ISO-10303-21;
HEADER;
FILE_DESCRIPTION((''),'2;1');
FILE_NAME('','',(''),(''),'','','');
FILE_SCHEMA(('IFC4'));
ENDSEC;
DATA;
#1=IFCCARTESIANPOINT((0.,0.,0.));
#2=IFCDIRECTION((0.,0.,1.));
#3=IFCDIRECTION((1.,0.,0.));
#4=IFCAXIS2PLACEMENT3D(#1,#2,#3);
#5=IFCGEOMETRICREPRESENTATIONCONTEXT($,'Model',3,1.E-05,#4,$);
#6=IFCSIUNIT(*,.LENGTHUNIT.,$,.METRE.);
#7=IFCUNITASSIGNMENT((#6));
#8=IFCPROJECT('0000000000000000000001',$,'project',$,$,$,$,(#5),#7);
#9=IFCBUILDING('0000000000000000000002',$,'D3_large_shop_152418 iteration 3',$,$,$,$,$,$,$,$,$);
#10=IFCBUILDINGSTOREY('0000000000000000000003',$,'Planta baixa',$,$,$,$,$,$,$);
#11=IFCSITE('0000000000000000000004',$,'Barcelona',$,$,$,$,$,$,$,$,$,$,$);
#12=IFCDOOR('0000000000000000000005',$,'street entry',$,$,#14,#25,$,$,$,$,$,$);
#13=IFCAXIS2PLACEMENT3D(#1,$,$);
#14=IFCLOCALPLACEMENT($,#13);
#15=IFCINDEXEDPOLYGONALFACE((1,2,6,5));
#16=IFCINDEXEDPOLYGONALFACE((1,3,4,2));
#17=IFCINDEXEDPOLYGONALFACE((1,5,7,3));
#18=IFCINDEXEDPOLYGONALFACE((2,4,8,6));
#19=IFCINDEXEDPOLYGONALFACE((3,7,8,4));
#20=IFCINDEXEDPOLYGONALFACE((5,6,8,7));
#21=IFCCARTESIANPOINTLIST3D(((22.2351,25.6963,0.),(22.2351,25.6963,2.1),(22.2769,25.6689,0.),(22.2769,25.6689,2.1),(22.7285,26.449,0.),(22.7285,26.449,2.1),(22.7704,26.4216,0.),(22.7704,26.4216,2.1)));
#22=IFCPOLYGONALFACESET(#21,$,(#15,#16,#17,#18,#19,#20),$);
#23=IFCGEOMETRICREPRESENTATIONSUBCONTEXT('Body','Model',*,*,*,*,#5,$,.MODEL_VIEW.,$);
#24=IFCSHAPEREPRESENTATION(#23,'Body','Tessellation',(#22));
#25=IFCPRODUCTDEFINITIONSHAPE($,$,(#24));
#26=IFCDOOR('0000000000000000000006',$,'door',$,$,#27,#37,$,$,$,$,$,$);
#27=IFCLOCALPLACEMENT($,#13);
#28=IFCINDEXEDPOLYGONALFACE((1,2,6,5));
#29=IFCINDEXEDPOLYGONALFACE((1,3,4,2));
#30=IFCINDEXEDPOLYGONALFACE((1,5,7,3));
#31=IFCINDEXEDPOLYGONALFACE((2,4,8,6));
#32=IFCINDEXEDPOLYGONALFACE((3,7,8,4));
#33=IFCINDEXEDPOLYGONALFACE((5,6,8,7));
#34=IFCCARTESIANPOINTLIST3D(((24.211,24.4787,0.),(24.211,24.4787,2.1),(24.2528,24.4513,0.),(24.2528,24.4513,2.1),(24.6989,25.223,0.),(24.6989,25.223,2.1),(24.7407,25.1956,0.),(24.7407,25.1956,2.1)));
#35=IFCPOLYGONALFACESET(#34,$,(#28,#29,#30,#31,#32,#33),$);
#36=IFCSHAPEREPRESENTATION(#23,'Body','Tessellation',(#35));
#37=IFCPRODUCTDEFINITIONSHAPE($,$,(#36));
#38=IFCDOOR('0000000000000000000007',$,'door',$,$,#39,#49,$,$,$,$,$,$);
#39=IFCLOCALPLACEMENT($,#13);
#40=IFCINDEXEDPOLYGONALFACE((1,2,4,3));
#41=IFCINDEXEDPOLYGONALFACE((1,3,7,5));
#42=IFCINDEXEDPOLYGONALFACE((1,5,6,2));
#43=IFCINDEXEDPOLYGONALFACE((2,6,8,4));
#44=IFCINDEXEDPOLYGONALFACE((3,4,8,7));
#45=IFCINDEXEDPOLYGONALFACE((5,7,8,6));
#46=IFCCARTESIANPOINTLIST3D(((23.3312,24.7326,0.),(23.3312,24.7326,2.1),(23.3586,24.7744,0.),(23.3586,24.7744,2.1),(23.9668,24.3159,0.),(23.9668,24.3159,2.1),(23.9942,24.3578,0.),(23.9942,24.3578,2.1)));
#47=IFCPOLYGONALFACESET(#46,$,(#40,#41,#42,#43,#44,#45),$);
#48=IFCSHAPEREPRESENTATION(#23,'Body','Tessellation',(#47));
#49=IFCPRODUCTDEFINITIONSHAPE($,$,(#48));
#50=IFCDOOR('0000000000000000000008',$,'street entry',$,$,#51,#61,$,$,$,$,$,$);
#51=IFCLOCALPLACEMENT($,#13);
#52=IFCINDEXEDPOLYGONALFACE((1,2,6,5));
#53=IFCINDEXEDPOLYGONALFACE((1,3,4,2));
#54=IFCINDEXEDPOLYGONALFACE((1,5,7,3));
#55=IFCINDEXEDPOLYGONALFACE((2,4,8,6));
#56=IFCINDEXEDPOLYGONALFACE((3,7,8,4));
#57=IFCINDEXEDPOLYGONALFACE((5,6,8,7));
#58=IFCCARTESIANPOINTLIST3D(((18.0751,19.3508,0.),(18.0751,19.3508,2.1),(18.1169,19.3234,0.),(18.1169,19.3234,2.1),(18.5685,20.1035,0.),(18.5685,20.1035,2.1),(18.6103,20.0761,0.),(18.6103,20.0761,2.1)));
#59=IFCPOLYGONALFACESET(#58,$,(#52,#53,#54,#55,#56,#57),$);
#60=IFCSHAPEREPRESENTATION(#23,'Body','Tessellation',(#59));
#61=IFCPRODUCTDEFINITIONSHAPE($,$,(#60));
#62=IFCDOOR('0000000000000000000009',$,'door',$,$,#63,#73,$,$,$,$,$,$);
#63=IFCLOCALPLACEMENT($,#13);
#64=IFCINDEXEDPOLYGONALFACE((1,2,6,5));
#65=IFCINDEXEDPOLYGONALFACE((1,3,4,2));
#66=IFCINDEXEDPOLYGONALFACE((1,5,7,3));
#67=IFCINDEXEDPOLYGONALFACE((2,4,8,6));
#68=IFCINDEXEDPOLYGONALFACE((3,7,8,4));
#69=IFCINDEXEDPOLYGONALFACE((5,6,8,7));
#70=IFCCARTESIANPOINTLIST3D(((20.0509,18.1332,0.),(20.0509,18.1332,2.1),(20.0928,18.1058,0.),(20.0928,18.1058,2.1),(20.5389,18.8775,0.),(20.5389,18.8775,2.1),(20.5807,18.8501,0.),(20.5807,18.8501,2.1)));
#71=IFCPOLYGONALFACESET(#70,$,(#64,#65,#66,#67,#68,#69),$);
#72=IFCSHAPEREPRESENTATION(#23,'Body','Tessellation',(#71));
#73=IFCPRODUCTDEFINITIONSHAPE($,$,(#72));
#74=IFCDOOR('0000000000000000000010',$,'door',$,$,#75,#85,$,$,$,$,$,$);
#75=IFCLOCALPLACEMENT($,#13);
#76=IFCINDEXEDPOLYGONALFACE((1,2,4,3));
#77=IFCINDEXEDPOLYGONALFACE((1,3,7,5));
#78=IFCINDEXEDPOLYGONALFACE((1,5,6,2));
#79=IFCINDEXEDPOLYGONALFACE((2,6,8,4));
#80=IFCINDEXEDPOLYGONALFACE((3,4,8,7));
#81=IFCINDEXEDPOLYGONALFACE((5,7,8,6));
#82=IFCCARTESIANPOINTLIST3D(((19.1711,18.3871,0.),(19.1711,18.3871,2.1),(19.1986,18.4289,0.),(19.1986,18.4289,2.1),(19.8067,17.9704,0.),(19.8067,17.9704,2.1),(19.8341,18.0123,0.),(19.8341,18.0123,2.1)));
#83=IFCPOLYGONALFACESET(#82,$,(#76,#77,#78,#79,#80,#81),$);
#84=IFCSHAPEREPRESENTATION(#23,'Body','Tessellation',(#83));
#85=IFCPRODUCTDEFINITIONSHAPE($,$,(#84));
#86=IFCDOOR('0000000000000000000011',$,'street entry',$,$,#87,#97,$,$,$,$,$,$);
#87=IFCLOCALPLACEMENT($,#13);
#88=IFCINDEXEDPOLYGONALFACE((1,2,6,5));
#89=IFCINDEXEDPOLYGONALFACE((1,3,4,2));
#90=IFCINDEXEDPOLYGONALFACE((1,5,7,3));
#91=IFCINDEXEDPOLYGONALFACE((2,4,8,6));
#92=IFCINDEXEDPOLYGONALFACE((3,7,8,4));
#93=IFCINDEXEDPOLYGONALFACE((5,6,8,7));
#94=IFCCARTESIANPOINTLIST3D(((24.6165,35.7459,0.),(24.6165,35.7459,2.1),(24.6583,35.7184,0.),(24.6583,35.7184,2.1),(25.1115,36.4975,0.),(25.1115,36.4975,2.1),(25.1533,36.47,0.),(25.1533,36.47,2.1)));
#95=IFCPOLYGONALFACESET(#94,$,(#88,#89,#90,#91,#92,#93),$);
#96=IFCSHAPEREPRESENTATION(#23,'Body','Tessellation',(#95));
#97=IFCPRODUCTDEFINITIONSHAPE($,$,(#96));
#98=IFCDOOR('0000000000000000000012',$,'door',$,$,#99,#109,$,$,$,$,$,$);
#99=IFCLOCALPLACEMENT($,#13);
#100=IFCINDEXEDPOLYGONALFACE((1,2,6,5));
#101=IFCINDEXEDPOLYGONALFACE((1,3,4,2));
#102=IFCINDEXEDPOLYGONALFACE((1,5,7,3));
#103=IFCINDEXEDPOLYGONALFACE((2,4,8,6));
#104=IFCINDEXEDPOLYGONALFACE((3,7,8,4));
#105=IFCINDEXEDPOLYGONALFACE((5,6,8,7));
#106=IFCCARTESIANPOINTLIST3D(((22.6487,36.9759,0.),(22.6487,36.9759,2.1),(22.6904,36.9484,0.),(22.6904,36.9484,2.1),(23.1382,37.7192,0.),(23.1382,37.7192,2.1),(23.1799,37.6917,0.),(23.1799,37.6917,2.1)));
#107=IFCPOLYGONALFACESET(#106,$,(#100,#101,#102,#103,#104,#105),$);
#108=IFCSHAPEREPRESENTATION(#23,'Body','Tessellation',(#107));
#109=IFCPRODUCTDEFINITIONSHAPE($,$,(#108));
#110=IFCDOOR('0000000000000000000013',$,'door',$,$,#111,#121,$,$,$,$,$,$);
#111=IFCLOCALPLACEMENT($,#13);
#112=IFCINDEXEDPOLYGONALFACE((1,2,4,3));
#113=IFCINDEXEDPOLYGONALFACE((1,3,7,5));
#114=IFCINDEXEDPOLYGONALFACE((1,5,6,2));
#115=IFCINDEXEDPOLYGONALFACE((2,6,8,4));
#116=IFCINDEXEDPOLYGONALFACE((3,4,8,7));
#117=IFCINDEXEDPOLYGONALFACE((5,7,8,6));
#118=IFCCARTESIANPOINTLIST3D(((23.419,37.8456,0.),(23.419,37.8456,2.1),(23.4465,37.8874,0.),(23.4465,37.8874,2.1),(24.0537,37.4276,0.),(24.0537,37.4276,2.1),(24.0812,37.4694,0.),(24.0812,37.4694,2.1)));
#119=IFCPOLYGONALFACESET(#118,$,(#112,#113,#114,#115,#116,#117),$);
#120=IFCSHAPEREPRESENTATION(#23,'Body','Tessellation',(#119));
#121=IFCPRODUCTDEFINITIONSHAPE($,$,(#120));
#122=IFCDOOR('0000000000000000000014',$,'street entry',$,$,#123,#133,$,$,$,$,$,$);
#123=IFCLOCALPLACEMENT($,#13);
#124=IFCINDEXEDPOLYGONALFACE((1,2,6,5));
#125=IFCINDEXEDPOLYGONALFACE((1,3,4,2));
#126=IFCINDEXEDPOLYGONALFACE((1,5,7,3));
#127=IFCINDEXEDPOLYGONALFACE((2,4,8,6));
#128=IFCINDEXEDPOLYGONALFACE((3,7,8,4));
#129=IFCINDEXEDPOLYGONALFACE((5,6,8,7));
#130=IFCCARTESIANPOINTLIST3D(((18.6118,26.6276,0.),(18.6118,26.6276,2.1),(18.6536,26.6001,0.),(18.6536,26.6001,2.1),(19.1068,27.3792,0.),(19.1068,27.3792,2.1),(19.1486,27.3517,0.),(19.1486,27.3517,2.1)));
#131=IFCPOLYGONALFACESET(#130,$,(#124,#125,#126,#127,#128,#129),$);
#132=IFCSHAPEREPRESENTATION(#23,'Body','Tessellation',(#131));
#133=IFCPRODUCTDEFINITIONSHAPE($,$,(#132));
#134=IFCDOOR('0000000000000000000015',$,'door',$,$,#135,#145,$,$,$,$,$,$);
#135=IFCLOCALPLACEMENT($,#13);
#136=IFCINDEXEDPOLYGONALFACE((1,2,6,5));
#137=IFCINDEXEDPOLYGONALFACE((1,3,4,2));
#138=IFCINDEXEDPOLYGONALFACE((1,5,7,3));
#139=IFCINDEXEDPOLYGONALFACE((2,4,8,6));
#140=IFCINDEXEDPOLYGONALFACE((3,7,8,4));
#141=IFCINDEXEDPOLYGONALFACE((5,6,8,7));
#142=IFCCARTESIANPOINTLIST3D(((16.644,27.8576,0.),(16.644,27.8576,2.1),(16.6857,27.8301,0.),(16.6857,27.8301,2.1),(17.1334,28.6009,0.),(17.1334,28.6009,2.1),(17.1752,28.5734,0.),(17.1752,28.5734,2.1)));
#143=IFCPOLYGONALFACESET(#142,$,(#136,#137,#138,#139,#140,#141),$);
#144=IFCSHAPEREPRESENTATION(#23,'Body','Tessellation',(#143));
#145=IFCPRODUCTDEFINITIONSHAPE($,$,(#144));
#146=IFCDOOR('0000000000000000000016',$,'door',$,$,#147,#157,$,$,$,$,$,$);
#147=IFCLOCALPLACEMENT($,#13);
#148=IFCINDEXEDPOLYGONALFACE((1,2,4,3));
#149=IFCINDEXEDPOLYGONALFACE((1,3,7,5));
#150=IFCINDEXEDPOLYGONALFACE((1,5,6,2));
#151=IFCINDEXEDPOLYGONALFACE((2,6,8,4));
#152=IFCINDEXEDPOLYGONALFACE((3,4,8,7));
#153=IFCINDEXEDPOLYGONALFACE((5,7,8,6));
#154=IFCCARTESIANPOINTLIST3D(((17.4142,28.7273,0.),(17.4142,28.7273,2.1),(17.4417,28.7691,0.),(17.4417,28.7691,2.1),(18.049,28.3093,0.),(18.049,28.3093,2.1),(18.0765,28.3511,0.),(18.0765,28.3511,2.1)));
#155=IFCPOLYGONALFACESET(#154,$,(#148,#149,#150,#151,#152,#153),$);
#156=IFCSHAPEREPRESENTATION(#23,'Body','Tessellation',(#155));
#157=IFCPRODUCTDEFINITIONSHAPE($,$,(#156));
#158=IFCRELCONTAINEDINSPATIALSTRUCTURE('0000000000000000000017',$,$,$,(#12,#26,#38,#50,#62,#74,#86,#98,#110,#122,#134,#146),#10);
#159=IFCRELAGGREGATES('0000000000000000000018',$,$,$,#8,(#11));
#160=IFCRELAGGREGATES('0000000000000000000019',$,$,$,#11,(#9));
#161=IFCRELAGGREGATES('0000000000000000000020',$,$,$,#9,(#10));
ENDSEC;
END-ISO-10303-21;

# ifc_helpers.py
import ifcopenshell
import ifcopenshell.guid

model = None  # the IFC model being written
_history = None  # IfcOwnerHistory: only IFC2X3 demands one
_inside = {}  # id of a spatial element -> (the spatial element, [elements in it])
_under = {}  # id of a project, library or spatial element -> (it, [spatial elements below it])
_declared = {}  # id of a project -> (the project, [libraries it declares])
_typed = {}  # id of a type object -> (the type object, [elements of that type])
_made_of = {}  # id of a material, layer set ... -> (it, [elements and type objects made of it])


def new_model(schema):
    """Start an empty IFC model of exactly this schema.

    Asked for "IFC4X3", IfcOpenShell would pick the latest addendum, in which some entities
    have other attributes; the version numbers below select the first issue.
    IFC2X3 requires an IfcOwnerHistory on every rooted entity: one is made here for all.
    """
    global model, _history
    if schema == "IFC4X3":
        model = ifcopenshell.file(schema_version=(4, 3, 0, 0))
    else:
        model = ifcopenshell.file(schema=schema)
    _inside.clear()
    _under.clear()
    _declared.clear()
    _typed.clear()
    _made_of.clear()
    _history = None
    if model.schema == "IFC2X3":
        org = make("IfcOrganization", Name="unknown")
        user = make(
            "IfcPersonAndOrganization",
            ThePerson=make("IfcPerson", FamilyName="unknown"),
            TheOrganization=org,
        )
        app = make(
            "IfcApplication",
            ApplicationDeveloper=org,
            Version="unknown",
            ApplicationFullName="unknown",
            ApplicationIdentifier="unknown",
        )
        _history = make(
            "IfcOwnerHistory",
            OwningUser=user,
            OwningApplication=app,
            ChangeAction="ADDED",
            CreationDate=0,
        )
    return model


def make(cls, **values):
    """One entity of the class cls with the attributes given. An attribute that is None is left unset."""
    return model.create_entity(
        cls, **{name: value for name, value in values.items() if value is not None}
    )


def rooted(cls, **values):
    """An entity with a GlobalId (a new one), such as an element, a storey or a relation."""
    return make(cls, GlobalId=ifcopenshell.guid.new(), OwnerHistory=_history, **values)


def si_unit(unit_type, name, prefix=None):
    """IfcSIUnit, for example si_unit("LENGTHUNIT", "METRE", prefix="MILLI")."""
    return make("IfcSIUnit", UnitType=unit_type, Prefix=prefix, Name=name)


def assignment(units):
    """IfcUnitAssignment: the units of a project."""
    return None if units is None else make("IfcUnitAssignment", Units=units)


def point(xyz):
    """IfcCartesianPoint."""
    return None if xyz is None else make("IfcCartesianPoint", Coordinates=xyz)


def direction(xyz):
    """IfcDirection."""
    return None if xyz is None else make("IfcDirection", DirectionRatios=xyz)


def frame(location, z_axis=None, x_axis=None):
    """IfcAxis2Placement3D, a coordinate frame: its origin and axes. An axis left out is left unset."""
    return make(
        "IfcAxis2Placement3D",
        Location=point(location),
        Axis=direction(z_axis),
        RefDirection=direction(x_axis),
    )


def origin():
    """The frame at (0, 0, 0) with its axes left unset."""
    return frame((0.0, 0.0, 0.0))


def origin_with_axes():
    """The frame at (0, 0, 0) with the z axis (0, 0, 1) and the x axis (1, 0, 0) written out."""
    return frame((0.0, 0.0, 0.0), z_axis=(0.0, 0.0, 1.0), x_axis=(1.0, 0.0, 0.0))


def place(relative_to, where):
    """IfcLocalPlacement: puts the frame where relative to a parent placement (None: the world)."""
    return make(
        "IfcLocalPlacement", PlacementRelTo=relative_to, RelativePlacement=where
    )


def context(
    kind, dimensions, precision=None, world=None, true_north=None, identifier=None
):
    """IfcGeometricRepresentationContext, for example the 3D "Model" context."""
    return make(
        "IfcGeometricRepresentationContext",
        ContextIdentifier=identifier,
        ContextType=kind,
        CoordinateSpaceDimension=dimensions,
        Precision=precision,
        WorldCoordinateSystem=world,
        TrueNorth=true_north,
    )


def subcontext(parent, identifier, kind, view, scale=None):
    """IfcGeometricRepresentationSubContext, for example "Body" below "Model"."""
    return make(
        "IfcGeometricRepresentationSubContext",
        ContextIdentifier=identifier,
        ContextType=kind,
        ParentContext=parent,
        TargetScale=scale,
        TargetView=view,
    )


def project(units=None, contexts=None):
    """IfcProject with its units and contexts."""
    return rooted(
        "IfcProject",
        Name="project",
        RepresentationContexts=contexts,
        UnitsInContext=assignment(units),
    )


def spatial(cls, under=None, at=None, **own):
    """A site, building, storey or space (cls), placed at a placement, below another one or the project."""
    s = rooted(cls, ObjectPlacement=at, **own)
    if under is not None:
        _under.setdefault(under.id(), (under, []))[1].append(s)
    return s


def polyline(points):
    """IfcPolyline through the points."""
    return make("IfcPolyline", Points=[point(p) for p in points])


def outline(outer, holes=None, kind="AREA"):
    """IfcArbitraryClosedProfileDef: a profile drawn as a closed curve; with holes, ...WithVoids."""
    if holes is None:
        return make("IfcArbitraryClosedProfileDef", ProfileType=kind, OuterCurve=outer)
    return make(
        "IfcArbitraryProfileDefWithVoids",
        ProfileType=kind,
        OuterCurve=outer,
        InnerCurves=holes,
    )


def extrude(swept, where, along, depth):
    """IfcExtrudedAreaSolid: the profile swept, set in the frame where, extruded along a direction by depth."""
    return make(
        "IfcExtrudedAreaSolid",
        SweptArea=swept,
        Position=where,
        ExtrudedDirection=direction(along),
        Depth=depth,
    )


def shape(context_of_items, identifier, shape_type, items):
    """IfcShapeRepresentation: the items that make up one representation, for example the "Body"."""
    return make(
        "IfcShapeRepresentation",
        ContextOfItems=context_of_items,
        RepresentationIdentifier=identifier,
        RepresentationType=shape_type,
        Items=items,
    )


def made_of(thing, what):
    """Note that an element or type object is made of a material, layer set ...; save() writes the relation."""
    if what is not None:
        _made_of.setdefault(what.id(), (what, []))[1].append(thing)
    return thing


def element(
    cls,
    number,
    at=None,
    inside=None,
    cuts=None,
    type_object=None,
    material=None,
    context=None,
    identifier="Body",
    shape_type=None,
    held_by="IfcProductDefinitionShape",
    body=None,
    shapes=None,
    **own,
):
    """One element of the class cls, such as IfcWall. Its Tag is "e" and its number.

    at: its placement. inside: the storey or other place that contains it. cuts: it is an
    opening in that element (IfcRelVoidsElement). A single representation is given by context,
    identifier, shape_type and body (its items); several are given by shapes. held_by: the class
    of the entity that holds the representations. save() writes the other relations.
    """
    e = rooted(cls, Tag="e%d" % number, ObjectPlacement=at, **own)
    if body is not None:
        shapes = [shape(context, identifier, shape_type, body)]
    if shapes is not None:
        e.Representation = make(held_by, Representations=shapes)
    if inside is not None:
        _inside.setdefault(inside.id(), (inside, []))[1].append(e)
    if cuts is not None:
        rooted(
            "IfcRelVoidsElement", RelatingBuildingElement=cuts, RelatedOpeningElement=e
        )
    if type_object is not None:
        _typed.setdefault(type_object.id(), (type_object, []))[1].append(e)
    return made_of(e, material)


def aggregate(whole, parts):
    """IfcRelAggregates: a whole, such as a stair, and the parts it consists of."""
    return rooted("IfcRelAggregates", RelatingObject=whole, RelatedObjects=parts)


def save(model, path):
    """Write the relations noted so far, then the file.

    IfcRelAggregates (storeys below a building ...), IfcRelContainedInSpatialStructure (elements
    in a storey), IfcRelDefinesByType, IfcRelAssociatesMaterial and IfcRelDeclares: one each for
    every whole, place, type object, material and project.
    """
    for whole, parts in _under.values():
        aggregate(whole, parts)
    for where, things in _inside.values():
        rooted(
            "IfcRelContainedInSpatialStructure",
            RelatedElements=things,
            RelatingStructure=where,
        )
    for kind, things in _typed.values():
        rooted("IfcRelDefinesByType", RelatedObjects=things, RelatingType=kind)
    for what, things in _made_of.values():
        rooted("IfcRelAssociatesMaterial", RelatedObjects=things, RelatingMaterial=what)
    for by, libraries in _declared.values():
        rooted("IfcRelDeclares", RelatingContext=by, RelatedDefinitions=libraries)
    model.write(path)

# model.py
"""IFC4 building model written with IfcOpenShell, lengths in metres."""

from ifc_helpers import new_model, si_unit, origin, origin_with_axes, place, context, subcontext, project, spatial, polyline, outline, extrude, element, save


model = new_model("IFC4")

# Units and contexts
model_context = context("Model", 3, precision=1e-05, world=origin_with_axes())
body_context = subcontext(model_context, "Body", "Model", "MODEL_VIEW")
ifc_project = project(units=[si_unit("LENGTHUNIT", "METRE")], contexts=[model_context])

# Site, building, storey
site = spatial("IfcSite", under=ifc_project, Name="Barcelona")
building = spatial("IfcBuilding", under=site, Name="D3_large_shop_152418 iteration 3")
storey = spatial("IfcBuildingStorey", under=building, Name="Planta baixa")

# Doors
door_1_placement = place(None, origin_with_axes())
element("IfcDoor", 1, at=door_1_placement, inside=storey, Name="street entry", context=body_context, shape_type="SweptSolid", body=[
    extrude(outline(polyline([(22.7704, 26.4216), (22.2769, 25.6689), (22.2351, 25.6963), (22.7285, 26.449), (22.7704, 26.4216)])), origin(), (0.0, 0.0, 1.0), 2.1),
])
door_2_placement = place(None, origin_with_axes())
element("IfcDoor", 2, at=door_2_placement, inside=storey, Name="door", context=body_context, shape_type="SweptSolid", body=[
    extrude(outline(polyline([(24.211, 24.4787), (24.6989, 25.223), (24.7407, 25.1956), (24.2528, 24.4513), (24.211, 24.4787)])), origin(), (0.0, 0.0, 1.0), 2.1),
])
door_3_placement = place(None, origin_with_axes())
element("IfcDoor", 3, at=door_3_placement, inside=storey, Name="door", context=body_context, shape_type="SweptSolid", body=[
    extrude(outline(polyline([(23.9668, 24.3159), (23.3312, 24.7326), (23.3586, 24.7744), (23.9942, 24.3578), (23.9668, 24.3159)])), origin(), (0.0, 0.0, 1.0), 2.1),
])
door_4_placement = place(None, origin_with_axes())
element("IfcDoor", 4, at=door_4_placement, inside=storey, Name="street entry", context=body_context, shape_type="SweptSolid", body=[
    extrude(outline(polyline([(18.6103, 20.0761), (18.1169, 19.3234), (18.0751, 19.3508), (18.5685, 20.1035), (18.6103, 20.0761)])), origin(), (0.0, 0.0, 1.0), 2.1),
])
door_5_placement = place(None, origin_with_axes())
element("IfcDoor", 5, at=door_5_placement, inside=storey, Name="door", context=body_context, shape_type="SweptSolid", body=[
    extrude(outline(polyline([(20.0509, 18.1332), (20.5389, 18.8775), (20.5807, 18.8501), (20.0928, 18.1058), (20.0509, 18.1332)])), origin(), (0.0, 0.0, 1.0), 2.1),
])
door_6_placement = place(None, origin_with_axes())
element("IfcDoor", 6, at=door_6_placement, inside=storey, Name="door", context=body_context, shape_type="SweptSolid", body=[
    extrude(outline(polyline([(19.8067, 17.9704), (19.1711, 18.3871), (19.1986, 18.4289), (19.8341, 18.0123), (19.8067, 17.9704)])), origin(), (0.0, 0.0, 1.0), 2.1),
])
door_7_placement = place(None, origin_with_axes())
element("IfcDoor", 7, at=door_7_placement, inside=storey, Name="street entry", context=body_context, shape_type="SweptSolid", body=[
    extrude(outline(polyline([(24.6165, 35.7459), (25.1115, 36.4975), (25.1533, 36.47), (24.6583, 35.7184), (24.6165, 35.7459)])), origin(), (0.0, 0.0, 1.0), 2.1),
])
door_8_placement = place(None, origin_with_axes())
element("IfcDoor", 8, at=door_8_placement, inside=storey, Name="door", context=body_context, shape_type="SweptSolid", body=[
    extrude(outline(polyline([(22.6487, 36.9759), (23.1382, 37.7192), (23.1799, 37.6917), (22.6904, 36.9484), (22.6487, 36.9759)])), origin(), (0.0, 0.0, 1.0), 2.1),
])
door_9_placement = place(None, origin_with_axes())
element("IfcDoor", 9, at=door_9_placement, inside=storey, Name="door", context=body_context, shape_type="SweptSolid", body=[
    extrude(outline(polyline([(23.4465, 37.8874), (24.0812, 37.4694), (24.0537, 37.4276), (23.419, 37.8456), (23.4465, 37.8874)])), origin(), (0.0, 0.0, 1.0), 2.1),
])
door_10_placement = place(None, origin_with_axes())
element("IfcDoor", 10, at=door_10_placement, inside=storey, Name="street entry", context=body_context, shape_type="SweptSolid", body=[
    extrude(outline(polyline([(18.6118, 26.6276), (19.1068, 27.3792), (19.1486, 27.3517), (18.6536, 26.6001), (18.6118, 26.6276)])), origin(), (0.0, 0.0, 1.0), 2.1),
])
door_11_placement = place(None, origin_with_axes())
element("IfcDoor", 11, at=door_11_placement, inside=storey, Name="door", context=body_context, shape_type="SweptSolid", body=[
    extrude(outline(polyline([(16.644, 27.8576), (17.1334, 28.6009), (17.1752, 28.5734), (16.6857, 27.8301), (16.644, 27.8576)])), origin(), (0.0, 0.0, 1.0), 2.1),
])
door_12_placement = place(None, origin_with_axes())
element("IfcDoor", 12, at=door_12_placement, inside=storey, Name="door", context=body_context, shape_type="SweptSolid", body=[
    extrude(outline(polyline([(17.4417, 28.7691), (18.0765, 28.3511), (18.049, 28.3093), (17.4142, 28.7273), (17.4417, 28.7691)])), origin(), (0.0, 0.0, 1.0), 2.1),
])

save(model, "model.ifc")
